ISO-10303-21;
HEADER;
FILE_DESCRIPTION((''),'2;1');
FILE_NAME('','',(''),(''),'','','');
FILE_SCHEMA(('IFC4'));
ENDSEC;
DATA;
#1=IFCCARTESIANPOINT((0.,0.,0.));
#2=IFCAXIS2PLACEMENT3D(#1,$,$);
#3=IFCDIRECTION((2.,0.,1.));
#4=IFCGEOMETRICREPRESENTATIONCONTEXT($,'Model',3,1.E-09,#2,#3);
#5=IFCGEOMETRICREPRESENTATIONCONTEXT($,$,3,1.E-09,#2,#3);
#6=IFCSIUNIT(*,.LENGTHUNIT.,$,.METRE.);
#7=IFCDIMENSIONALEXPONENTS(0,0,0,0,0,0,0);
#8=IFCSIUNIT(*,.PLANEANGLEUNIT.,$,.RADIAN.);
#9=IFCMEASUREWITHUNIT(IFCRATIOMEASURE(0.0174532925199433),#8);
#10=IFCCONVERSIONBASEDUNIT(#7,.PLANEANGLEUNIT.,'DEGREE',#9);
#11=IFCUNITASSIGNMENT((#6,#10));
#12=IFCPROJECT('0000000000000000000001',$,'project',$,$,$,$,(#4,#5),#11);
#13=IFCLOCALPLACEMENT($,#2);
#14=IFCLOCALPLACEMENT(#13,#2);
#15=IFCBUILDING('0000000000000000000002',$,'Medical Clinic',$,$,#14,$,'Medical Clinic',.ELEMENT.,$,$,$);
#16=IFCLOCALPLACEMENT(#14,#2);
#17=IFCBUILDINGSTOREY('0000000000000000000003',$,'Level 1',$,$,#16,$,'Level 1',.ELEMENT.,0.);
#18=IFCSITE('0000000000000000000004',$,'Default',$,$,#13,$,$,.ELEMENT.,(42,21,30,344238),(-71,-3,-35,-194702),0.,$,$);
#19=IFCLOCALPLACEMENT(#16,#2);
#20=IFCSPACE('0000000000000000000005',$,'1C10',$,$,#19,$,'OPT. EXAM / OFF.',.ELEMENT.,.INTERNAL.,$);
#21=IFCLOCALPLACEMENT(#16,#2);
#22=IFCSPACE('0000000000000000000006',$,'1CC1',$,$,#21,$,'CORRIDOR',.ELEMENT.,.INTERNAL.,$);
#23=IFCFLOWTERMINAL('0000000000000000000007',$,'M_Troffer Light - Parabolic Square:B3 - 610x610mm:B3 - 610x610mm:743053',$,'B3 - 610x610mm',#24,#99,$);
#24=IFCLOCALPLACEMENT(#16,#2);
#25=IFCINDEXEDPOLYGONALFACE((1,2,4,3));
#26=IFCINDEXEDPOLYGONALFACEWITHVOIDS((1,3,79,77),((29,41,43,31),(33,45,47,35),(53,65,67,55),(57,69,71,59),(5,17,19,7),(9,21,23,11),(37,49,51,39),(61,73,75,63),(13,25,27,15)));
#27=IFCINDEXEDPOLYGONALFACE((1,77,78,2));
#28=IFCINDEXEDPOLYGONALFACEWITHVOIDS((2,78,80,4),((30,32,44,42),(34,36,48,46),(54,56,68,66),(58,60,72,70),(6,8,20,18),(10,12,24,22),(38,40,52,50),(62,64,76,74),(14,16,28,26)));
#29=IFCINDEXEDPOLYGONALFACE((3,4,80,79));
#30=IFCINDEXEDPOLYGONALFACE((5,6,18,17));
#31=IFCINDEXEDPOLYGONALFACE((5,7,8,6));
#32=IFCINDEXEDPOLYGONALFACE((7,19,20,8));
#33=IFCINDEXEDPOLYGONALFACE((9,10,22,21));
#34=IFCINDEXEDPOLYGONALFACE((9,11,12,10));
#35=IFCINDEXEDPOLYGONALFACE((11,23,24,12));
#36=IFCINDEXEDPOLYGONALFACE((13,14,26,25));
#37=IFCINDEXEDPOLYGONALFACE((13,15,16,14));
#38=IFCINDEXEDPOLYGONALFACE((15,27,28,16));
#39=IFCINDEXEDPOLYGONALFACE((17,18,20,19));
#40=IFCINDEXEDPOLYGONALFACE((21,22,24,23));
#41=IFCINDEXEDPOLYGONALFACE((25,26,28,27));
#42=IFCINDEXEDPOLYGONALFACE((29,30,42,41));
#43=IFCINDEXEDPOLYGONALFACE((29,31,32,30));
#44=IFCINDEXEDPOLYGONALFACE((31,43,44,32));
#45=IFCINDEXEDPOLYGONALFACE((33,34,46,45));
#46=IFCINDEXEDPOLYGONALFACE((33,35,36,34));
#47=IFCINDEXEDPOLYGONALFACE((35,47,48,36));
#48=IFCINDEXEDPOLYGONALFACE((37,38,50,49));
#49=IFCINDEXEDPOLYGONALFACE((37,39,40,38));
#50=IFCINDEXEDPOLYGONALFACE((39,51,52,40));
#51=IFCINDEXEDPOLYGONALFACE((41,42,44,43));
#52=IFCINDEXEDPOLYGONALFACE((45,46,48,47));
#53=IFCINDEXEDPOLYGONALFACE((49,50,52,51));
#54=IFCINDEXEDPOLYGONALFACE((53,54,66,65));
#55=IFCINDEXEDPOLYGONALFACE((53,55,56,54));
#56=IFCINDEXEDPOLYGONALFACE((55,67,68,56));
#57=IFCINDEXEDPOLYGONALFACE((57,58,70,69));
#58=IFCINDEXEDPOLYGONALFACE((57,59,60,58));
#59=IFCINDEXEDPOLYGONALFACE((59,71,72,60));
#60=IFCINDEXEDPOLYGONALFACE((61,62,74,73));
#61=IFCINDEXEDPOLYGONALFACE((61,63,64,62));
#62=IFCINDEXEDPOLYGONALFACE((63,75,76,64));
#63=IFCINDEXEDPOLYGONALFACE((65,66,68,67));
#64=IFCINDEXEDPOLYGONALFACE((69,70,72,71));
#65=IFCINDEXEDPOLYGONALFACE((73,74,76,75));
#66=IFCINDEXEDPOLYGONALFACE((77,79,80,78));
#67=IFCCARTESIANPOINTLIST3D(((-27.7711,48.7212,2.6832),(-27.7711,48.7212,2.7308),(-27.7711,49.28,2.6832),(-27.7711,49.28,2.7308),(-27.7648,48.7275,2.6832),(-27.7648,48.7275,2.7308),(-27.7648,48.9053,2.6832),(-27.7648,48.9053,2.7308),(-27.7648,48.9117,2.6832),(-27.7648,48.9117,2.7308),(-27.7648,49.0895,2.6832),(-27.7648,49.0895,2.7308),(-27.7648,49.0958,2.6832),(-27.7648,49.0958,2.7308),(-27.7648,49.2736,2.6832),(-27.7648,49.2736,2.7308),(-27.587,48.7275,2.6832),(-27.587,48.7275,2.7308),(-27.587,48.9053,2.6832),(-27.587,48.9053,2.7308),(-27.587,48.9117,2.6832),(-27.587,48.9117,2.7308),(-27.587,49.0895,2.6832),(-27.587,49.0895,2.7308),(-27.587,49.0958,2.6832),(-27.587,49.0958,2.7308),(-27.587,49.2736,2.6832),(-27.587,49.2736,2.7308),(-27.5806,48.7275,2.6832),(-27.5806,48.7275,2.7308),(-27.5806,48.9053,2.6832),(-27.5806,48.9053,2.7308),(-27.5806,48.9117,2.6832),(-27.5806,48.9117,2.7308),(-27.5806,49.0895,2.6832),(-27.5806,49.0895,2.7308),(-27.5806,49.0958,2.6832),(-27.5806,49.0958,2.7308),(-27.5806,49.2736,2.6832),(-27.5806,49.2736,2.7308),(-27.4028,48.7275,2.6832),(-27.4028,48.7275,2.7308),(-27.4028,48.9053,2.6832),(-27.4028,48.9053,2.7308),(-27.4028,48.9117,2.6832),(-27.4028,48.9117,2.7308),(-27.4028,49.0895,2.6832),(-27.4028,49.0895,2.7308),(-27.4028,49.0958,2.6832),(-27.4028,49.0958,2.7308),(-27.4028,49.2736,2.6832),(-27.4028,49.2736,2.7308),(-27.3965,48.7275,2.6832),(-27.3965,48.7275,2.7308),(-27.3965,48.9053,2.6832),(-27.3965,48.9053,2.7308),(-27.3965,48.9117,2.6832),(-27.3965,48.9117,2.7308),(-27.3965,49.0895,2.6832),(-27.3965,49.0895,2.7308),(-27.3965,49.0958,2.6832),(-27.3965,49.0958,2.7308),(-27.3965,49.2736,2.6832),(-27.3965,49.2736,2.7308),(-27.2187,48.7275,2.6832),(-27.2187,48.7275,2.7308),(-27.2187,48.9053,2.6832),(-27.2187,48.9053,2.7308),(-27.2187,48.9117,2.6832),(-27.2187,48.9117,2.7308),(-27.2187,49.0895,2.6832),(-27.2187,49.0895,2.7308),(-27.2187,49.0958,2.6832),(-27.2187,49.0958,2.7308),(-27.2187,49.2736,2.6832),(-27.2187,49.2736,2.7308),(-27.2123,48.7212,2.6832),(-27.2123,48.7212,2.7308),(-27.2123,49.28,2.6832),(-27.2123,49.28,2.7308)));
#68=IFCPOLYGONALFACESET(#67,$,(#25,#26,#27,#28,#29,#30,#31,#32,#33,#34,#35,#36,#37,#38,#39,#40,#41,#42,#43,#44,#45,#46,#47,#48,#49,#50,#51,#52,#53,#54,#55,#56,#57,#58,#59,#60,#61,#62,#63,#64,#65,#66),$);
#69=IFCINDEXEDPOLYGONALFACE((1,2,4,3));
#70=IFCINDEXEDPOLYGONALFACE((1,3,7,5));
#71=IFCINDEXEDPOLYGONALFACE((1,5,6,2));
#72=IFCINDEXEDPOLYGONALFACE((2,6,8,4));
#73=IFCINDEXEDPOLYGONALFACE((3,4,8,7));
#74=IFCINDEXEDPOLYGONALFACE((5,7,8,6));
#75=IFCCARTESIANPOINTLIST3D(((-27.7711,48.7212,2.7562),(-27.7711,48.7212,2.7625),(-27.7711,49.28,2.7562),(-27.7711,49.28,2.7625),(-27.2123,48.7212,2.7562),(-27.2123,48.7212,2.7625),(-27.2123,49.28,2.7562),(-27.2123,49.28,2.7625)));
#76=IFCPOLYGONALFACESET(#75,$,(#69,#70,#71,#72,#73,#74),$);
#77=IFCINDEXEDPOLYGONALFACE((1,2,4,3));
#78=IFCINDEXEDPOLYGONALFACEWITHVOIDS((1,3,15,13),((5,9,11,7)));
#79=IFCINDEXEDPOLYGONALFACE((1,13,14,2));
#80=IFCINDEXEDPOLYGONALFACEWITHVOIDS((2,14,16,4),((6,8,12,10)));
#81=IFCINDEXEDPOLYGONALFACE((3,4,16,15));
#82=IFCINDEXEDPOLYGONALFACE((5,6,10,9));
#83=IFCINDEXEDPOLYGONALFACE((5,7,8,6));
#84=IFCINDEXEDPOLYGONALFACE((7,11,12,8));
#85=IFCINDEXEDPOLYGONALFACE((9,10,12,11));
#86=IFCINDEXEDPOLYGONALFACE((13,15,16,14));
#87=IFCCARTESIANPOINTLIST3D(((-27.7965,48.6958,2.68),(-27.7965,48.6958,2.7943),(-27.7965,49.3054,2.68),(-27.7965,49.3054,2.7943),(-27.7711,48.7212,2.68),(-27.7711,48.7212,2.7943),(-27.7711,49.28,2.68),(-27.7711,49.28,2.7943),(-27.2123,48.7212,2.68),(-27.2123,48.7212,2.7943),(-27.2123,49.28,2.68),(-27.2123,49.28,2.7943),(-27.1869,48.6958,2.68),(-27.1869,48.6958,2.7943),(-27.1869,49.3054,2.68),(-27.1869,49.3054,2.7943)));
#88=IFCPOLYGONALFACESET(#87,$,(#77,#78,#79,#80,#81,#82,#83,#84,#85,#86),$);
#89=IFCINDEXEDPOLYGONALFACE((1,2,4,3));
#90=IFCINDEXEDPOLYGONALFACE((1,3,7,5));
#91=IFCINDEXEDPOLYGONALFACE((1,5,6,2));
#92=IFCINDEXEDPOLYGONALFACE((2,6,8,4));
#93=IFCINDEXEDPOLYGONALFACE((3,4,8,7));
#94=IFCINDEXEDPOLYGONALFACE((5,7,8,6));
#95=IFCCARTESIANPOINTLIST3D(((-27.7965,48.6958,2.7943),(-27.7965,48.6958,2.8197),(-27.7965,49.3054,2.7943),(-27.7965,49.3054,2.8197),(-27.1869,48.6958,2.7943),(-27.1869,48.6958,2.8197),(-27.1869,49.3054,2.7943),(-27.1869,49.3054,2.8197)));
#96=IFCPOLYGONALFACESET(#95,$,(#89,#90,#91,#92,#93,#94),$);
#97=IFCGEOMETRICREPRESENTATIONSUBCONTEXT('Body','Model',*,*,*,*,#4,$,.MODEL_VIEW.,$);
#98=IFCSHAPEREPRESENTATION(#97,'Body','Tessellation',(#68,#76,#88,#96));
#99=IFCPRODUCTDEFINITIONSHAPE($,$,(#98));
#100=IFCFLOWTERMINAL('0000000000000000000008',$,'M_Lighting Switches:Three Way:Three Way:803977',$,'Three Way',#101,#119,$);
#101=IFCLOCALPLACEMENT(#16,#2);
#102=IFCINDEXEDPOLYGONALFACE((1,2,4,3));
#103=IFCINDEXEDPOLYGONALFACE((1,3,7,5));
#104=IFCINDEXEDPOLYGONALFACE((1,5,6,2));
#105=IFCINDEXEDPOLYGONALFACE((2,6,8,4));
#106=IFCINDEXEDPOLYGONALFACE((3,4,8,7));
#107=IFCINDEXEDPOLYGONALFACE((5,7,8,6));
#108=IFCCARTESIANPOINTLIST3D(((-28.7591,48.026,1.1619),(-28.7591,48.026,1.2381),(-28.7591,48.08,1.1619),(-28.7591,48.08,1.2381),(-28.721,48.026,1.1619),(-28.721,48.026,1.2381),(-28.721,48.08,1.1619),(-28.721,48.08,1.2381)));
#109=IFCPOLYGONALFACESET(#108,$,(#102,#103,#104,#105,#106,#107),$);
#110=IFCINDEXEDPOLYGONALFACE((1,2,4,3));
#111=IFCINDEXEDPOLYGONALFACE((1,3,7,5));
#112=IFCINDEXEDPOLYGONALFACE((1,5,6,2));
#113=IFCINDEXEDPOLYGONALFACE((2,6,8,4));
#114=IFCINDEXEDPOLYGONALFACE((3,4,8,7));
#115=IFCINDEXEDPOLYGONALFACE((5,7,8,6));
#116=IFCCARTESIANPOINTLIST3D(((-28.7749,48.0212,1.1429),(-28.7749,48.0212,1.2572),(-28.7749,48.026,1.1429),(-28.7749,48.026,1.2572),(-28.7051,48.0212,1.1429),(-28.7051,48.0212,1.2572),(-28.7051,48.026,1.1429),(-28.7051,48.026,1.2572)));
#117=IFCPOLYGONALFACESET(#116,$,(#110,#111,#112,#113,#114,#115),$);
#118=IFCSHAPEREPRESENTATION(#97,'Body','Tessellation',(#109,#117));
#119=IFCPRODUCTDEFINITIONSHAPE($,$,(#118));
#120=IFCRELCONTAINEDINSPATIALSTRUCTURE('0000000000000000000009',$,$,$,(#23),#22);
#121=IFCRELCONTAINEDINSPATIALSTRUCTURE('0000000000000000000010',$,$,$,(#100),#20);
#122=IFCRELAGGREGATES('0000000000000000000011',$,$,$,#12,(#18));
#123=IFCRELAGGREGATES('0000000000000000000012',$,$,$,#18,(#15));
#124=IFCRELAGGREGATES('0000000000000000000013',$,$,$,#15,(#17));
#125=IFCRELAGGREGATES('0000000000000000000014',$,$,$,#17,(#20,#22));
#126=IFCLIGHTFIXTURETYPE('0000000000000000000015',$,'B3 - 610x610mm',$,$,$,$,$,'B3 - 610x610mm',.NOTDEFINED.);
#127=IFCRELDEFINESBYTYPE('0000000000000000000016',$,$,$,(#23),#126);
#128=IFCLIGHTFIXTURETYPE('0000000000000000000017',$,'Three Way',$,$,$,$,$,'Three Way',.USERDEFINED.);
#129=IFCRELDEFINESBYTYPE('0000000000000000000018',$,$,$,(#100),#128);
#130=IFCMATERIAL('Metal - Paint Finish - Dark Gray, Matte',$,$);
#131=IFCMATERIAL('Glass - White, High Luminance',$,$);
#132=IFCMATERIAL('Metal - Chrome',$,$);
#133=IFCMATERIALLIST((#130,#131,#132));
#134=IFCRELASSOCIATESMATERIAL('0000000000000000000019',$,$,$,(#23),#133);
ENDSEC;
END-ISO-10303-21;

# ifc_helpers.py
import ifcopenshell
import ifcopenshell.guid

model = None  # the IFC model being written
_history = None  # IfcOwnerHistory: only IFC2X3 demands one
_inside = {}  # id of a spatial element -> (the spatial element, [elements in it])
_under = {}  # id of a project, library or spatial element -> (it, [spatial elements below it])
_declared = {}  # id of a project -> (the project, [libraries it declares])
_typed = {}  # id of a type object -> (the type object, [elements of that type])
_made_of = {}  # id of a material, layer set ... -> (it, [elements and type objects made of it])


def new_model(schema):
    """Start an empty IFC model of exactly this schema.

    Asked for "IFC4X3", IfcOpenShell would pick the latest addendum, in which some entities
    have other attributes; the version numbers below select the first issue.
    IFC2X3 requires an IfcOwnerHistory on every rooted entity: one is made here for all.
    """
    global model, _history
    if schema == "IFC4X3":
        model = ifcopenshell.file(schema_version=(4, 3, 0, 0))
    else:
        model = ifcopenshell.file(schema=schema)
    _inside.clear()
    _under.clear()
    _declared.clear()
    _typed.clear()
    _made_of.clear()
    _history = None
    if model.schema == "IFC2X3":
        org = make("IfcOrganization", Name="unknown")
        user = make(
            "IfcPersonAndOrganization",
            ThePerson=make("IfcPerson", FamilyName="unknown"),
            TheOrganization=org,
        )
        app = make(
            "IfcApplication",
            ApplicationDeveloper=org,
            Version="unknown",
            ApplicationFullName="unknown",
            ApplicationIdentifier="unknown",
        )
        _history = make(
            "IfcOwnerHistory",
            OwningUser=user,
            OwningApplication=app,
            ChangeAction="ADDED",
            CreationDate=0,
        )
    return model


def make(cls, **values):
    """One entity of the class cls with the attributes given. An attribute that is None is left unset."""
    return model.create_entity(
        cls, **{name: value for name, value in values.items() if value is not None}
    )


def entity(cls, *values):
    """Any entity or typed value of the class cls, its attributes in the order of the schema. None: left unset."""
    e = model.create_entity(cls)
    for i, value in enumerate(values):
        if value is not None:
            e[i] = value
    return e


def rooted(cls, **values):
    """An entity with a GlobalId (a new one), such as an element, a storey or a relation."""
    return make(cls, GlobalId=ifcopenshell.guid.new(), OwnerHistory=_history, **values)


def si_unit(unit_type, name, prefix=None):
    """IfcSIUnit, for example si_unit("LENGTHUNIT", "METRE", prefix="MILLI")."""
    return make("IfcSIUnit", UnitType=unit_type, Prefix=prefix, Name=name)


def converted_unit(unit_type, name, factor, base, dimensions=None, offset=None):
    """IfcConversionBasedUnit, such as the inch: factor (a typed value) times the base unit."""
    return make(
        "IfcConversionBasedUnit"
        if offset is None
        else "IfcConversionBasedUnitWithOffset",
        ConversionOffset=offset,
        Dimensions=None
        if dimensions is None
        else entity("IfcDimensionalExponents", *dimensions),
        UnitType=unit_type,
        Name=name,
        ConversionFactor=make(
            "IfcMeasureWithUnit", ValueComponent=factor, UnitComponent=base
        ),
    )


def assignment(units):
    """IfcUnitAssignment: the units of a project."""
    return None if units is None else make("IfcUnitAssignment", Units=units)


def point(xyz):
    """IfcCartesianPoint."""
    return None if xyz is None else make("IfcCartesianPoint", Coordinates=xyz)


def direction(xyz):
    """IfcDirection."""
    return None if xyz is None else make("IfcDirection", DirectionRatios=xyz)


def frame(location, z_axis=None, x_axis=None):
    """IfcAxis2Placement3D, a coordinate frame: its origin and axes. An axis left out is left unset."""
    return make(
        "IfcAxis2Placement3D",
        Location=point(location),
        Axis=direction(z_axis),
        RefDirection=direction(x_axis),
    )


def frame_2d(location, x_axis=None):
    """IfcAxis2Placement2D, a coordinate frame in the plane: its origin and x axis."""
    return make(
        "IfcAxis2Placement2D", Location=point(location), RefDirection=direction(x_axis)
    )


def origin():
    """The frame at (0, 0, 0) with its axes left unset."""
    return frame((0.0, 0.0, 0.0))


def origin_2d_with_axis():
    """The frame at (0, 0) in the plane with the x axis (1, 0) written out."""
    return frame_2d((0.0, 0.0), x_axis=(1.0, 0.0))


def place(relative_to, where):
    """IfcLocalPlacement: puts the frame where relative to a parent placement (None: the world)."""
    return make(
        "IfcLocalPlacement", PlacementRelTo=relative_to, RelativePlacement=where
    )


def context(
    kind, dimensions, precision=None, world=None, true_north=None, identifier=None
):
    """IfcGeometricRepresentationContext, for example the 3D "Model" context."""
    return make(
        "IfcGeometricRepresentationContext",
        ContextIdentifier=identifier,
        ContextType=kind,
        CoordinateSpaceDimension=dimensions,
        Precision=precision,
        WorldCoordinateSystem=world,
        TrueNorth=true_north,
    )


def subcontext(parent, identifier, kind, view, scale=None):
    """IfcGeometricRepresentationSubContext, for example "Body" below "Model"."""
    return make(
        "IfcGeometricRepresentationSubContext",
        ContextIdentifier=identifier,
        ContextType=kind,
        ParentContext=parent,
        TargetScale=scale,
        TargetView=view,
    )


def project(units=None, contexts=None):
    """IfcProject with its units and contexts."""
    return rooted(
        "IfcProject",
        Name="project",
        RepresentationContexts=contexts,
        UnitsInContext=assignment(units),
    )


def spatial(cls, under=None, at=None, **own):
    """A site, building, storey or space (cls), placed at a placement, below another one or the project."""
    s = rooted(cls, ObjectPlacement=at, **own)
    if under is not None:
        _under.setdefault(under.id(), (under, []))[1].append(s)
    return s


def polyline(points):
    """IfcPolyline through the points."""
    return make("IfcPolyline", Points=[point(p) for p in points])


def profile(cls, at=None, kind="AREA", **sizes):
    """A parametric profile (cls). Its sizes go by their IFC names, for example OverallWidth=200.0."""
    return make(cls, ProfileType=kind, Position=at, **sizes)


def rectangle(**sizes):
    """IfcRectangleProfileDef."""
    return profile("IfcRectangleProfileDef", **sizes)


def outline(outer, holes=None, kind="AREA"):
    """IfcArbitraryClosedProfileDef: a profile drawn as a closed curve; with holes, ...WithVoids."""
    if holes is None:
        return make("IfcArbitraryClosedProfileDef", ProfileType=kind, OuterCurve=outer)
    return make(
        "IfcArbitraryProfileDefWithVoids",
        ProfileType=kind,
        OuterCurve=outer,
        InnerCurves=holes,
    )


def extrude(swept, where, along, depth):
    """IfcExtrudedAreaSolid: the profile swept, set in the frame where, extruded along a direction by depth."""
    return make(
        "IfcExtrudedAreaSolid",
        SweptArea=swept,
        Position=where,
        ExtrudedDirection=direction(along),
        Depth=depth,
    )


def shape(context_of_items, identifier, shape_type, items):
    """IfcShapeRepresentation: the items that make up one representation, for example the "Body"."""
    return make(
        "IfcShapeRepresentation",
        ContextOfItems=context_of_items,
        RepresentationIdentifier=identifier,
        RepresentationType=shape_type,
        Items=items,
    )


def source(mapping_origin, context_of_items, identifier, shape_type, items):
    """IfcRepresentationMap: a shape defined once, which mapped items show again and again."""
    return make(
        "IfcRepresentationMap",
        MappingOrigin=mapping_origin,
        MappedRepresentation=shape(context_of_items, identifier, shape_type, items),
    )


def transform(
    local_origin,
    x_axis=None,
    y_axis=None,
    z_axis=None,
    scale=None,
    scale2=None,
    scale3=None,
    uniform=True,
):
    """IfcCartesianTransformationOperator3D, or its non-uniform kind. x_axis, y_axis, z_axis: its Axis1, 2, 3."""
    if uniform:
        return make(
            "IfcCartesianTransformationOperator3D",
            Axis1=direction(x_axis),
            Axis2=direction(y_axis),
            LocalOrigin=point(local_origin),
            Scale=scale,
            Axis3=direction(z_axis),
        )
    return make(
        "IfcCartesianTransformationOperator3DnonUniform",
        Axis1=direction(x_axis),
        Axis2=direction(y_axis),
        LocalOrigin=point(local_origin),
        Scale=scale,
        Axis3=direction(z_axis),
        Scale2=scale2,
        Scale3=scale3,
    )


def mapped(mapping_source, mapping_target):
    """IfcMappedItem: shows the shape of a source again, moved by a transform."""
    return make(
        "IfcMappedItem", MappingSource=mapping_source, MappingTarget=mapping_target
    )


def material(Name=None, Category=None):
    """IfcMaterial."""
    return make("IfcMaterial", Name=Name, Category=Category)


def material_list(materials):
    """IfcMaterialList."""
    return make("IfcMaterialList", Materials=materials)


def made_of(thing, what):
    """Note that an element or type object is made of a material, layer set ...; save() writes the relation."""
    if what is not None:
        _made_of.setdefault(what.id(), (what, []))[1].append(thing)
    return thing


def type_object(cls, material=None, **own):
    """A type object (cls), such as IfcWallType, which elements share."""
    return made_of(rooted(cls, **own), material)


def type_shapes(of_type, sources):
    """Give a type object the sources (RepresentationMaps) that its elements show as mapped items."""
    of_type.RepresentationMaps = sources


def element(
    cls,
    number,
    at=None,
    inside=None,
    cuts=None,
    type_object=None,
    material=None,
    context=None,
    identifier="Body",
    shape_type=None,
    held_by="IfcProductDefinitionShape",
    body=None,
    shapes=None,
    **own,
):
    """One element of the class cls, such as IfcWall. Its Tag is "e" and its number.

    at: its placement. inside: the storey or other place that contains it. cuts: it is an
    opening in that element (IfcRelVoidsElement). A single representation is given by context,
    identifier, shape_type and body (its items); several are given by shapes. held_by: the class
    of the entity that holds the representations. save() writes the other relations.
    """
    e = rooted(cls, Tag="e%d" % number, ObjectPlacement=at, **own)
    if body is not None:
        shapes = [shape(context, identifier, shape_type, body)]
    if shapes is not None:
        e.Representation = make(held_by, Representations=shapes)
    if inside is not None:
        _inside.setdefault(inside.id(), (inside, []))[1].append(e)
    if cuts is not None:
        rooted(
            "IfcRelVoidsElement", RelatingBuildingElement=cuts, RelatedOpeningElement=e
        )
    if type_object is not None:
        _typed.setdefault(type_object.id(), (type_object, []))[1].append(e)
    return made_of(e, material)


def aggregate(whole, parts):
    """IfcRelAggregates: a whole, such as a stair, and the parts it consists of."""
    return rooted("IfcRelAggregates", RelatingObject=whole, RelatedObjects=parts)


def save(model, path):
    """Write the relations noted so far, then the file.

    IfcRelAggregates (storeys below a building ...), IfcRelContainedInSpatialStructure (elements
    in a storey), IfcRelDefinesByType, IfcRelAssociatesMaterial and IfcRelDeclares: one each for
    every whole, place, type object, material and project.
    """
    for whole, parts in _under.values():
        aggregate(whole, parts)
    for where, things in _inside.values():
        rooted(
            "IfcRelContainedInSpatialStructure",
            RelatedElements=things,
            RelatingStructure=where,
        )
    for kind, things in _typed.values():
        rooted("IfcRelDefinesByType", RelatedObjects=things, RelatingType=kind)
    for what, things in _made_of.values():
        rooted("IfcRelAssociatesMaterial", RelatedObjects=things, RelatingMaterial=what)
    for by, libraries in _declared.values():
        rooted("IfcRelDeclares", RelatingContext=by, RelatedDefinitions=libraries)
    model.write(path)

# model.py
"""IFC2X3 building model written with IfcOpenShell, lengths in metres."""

from ifc_helpers import new_model, entity, si_unit, converted_unit, direction, frame, frame_2d, origin, origin_2d_with_axis, place, context, subcontext, project, spatial, polyline, rectangle, outline, extrude, source, transform, mapped, material, material_list, type_object, type_shapes, element, save


model = new_model("IFC2X3")

# Units and contexts
model_context = context("Model", 3, precision=1e-09, world=origin(), true_north=direction((2.0, 0.0, 1.0)))
context_of_model = context(None, 3, precision=1e-09, world=origin(), true_north=direction((2.0, 0.0, 1.0)))
body_context = subcontext(model_context, "Body", "Model", "MODEL_VIEW")
ifc_project = project(units=[si_unit("LENGTHUNIT", "METRE"), converted_unit("PLANEANGLEUNIT", "DEGREE", entity("IfcRatioMeasure", 0.0174532925199433), si_unit("PLANEANGLEUNIT", "RADIAN"), dimensions=[0, 0, 0, 0, 0, 0, 0])], contexts=[model_context, context_of_model])

# Site, building, storey
site_placement = place(None, origin())
site = spatial("IfcSite", under=ifc_project, at=site_placement, Name="Default", CompositionType="ELEMENT", RefLatitude=(42, 21, 30, 344238), RefLongitude=(-71, -3, -35, -194702), RefElevation=0.0)
building_placement = place(site_placement, origin())
building = spatial("IfcBuilding", under=site, at=building_placement, Name="Medical Clinic", LongName="Medical Clinic", CompositionType="ELEMENT")
storey_placement = place(building_placement, origin())
storey = spatial("IfcBuildingStorey", under=building, at=storey_placement, Name="Level 1", LongName="Level 1", CompositionType="ELEMENT", Elevation=0.0)

# Shared definitions
space_1_placement = place(storey_placement, origin())
space_1 = spatial("IfcSpace", under=storey, at=space_1_placement, Name="1C10", LongName="OPT. EXAM / OFF.", CompositionType="ELEMENT", InteriorOrExteriorSpace="INTERNAL")

# Shared definitions
space_2_placement = place(storey_placement, origin())
space_2 = spatial("IfcSpace", under=storey, at=space_2_placement, Name="1CC1", LongName="CORRIDOR", CompositionType="ELEMENT", InteriorOrExteriorSpace="INTERNAL")

# Flow terminals
ifc_material_1 = material(Name="Metal - Paint Finish - Dark Gray, Matte")
ifc_material_2 = material(Name="Glass - White, High Luminance")
ifc_material_3 = material(Name="Metal - Chrome")
ifc_material_list = material_list([ifc_material_1, ifc_material_2, ifc_material_3])
light_fixture_type_1 = type_object("IfcLightFixtureType", Name="B3 - 610x610mm", ElementType="B3 - 610x610mm", PredefinedType="NOTDEFINED")
shared_shape_1 = source(origin(), body_context, "Body", "SweptSolid", [
    extrude(outline(polyline([(-0.2794, -0.2794), (0.2794, -0.2794), (0.2794, 0.2794), (-0.2794, 0.2794), (-0.2794, -0.2794)]), holes=[polyline([(-0.0952, 0.0953), (-0.273, 0.0953), (-0.273, 0.2731), (-0.0952, 0.2731), (-0.0952, 0.0953)]), polyline([(0.2731, 0.0953), (0.0953, 0.0953), (0.0953, 0.2731), (0.2731, 0.2731), (0.2731, 0.0953)]), polyline([(-0.0889, 0.2731), (0.0889, 0.2731), (0.0889, 0.0953), (-0.0889, 0.0953), (-0.0889, 0.2731)]), polyline([(0.2731, -0.273), (0.0953, -0.273), (0.0953, -0.0952), (0.2731, -0.0952), (0.2731, -0.273)]), polyline([(0.0889, -0.273), (-0.0889, -0.273), (-0.0889, -0.0952), (0.0889, -0.0952), (0.0889, -0.273)]), polyline([(-0.0952, -0.273), (-0.273, -0.273), (-0.273, -0.0952), (-0.0952, -0.0952), (-0.0952, -0.273)]), polyline([(-0.0952, -0.0889), (-0.273, -0.0889), (-0.273, 0.0889), (-0.0952, 0.0889), (-0.0952, -0.0889)]), polyline([(0.0889, -0.0889), (-0.0889, -0.0889), (-0.0889, 0.0889), (0.0889, 0.0889), (0.0889, -0.0889)]), polyline([(0.2731, -0.0889), (0.0953, -0.0889), (0.0953, 0.0889), (0.2731, 0.0889), (0.2731, -0.0889)])]), frame((0.0, -0.3048, -0.0508), z_axis=(0.0, 0.0, 1.0), x_axis=(-1.0, 0.0, 0.0)), (0.0, 0.0, 1.0), 0.0476),
    extrude(rectangle(XDim=0.5588, YDim=0.5588, at=origin_2d_with_axis()), frame((0.0, -0.3048, -0.0825), z_axis=(0.0, 0.0, 1.0), x_axis=(-1.0, 0.0, 0.0)), (0.0, 0.0, 1.0), 0.0064),
    extrude(outline(polyline([(-0.3048, -0.3048), (0.3048, -0.3048), (0.3048, 0.3048), (-0.3048, 0.3048), (-0.3048, -0.3048)]), holes=[polyline([(0.2794, 0.2794), (0.2794, -0.2794), (-0.2794, -0.2794), (-0.2794, 0.2794), (0.2794, 0.2794)])]), frame((0.0, -0.3048, -0.1143)), (0.0, 0.0, 1.0), 0.1143),
    extrude(rectangle(XDim=0.6096, YDim=0.6096, at=origin_2d_with_axis()), frame((0.0, -0.3048, -0.1397), z_axis=(0.0, 0.0, 1.0), x_axis=(-1.0, 0.0, 0.0)), (0.0, 0.0, 1.0), 0.0254),
])
type_shapes(light_fixture_type_1, [shared_shape_1])
flow_terminal_1_placement = place(space_2_placement, frame((-27.4917, 48.6958, 2.68), z_axis=(0.0, 0.0, -1.0), x_axis=(1.0, 0.0, 0.0)))
element("IfcFlowTerminal", 1, at=flow_terminal_1_placement, inside=space_2, type_object=light_fixture_type_1, material=ifc_material_list, Name="M_Troffer Light - Parabolic Square:B3 - 610x610mm:B3 - 610x610mm:743053", ObjectType="B3 - 610x610mm", context=body_context, shape_type="MappedRepresentation", body=[
    mapped(shared_shape_1, transform((0.0, 0.0, 0.0), scale=1.0)),
])
light_fixture_type_2 = type_object("IfcLightFixtureType", Name="Three Way", ElementType="Three Way", PredefinedType="USERDEFINED")
shared_shape_2 = source(origin(), body_context, "Body", "SweptSolid", [
    extrude(rectangle(XDim=0.0381, YDim=0.0762, at=origin_2d_with_axis()), frame((0.0, 0.0, -0.054), z_axis=(0.0, 0.0, 1.0), x_axis=(-1.0, 0.0, 0.0)), (0.0, 0.0, 1.0), 0.054),
    extrude(rectangle(XDim=0.0698, YDim=0.1143, at=frame_2d((0.0, 0.0), x_axis=(1.0, 0.0))), frame((0.0, 0.0, 0.0), z_axis=(0.0, 0.0, 1.0), x_axis=(-1.0, 0.0, 0.0)), (0.0, 0.0, 1.0), 0.0048),
])
type_shapes(light_fixture_type_2, [shared_shape_2])
flow_terminal_2_placement = place(space_1_placement, frame((-28.74, 48.026, 1.2), z_axis=(0.0, -1.0, 0.0), x_axis=(1.0, 0.0, 0.0)))
element("IfcFlowTerminal", 2, at=flow_terminal_2_placement, inside=space_1, type_object=light_fixture_type_2, Name="M_Lighting Switches:Three Way:Three Way:803977", ObjectType="Three Way", context=body_context, shape_type="MappedRepresentation", body=[
    mapped(shared_shape_2, transform((0.0, 0.0, 0.0), scale=1.0)),
])

save(model, "model.ifc")
